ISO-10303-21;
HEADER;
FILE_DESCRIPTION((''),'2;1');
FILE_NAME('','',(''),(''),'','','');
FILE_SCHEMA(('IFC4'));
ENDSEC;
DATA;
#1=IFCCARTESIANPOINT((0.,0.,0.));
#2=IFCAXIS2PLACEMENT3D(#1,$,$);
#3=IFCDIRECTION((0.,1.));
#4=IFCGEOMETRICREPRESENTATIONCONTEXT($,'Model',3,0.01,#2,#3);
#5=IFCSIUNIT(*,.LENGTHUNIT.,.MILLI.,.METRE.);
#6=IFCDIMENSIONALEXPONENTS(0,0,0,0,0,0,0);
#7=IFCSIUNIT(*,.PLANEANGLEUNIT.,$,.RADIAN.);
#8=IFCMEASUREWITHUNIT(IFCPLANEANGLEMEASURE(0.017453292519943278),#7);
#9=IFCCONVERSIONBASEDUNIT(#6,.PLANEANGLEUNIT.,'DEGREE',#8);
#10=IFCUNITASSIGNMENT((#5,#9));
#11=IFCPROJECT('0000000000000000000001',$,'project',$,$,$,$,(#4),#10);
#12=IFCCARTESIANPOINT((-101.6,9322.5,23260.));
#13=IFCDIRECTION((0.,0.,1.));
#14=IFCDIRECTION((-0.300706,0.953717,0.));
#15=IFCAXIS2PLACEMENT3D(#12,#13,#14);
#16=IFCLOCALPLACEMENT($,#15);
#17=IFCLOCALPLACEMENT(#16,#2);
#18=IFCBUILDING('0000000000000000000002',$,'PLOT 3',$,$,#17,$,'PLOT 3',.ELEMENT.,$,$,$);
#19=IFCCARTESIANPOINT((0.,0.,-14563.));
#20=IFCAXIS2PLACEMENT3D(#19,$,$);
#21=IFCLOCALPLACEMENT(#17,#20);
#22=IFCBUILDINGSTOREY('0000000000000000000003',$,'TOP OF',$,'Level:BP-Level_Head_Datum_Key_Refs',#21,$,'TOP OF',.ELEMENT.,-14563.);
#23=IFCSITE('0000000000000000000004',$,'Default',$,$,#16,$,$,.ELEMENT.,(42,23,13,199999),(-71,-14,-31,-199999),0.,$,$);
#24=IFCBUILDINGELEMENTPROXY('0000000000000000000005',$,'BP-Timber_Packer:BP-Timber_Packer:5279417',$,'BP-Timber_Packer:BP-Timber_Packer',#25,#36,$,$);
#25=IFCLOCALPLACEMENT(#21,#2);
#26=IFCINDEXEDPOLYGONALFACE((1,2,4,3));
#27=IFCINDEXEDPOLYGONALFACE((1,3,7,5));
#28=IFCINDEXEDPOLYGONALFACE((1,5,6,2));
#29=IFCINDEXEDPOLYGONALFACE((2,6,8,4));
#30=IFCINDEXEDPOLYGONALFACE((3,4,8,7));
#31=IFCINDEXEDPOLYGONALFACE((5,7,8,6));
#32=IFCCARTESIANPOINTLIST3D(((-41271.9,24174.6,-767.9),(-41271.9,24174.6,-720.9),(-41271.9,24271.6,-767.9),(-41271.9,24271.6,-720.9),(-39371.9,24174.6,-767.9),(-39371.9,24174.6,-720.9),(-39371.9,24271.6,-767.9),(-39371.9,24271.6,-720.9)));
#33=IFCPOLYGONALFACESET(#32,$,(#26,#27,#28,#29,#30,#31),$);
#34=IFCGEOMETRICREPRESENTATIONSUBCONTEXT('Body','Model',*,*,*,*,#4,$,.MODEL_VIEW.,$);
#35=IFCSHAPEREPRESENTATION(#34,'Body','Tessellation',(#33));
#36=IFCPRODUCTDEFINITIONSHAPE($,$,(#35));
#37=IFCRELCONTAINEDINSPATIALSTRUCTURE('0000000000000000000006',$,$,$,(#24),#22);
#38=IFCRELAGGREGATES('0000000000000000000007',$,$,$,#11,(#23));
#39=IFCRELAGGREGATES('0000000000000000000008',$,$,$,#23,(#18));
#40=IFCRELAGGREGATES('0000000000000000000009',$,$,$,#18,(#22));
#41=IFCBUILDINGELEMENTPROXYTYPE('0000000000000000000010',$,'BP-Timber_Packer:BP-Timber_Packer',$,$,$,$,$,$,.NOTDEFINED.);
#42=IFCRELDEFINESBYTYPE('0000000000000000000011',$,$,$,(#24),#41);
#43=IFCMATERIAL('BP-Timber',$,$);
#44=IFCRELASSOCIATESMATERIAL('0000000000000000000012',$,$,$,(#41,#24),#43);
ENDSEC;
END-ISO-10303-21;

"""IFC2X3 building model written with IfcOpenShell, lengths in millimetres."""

from ifc_helpers import new_model, entity, si_unit, converted_unit, direction, frame, origin, origin_2d_with_axis, place, context, subcontext, project, spatial, rectangle, extrude, source, transform, mapped, material, type_object, type_shapes, element, save


model = new_model("IFC2X3")

# Units and contexts
model_context = context("Model", 3, precision=0.01, world=origin(), true_north=direction((0.0, 1.0)))
body_context = subcontext(model_context, "Body", "Model", "MODEL_VIEW")
ifc_project = project(units=[si_unit("LENGTHUNIT", "METRE", prefix="MILLI"), converted_unit("PLANEANGLEUNIT", "DEGREE", entity("IfcPlaneAngleMeasure", 0.017453292519943278), si_unit("PLANEANGLEUNIT", "RADIAN"), dimensions=[0, 0, 0, 0, 0, 0, 0])], contexts=[model_context])

# Site, building, storey
site_placement = place(None, frame((-101.6, 9322.5, 23260.0), z_axis=(0.0, 0.0, 1.0), x_axis=(-0.300706, 0.953717, 0.0)))
site = spatial("IfcSite", under=ifc_project, at=site_placement, Name="Default", CompositionType="ELEMENT", RefLatitude=(42, 23, 13, 199999), RefLongitude=(-71, -14, -31, -199999), RefElevation=0.0)
building_placement = place(site_placement, origin())
building = spatial("IfcBuilding", under=site, at=building_placement, Name="PLOT 3", LongName="PLOT 3", CompositionType="ELEMENT")
storey_placement = place(building_placement, frame((0.0, 0.0, -14563.0)))
storey = spatial("IfcBuildingStorey", under=building, at=storey_placement, Name="TOP OF", ObjectType="Level:BP-Level_Head_Datum_Key_Refs", LongName="TOP OF", CompositionType="ELEMENT", Elevation=-14563.0)

# Building element proxy
ifc_material = material(Name="BP-Timber")
building_element_proxy_type = type_object("IfcBuildingElementProxyType", Name="BP-Timber_Packer:BP-Timber_Packer", PredefinedType="NOTDEFINED", material=ifc_material)
shared_shape = source(origin(), body_context, "Body", "SweptSolid", [
    extrude(rectangle(XDim=1899.9, YDim=97.0, at=origin_2d_with_axis()), frame((0.0, 0.0, 0.0), z_axis=(0.0, 0.0, 1.0), x_axis=(-1.0, 0.0, 0.0)), (0.0, 0.0, 1.0), 47.0),
])
type_shapes(building_element_proxy_type, [shared_shape])
proxy_placement = place(storey_placement, frame((-40321.9, 24223.1, -767.9)))
element("IfcBuildingElementProxy", 1, at=proxy_placement, inside=storey, type_object=building_element_proxy_type, material=ifc_material, Name="BP-Timber_Packer:BP-Timber_Packer:5279417", ObjectType="BP-Timber_Packer:BP-Timber_Packer", context=body_context, shape_type="MappedRepresentation", body=[
    mapped(shared_shape, transform((0.0, 0.0, 0.0), scale=1.0)),
])

save(model, "model.ifc")
